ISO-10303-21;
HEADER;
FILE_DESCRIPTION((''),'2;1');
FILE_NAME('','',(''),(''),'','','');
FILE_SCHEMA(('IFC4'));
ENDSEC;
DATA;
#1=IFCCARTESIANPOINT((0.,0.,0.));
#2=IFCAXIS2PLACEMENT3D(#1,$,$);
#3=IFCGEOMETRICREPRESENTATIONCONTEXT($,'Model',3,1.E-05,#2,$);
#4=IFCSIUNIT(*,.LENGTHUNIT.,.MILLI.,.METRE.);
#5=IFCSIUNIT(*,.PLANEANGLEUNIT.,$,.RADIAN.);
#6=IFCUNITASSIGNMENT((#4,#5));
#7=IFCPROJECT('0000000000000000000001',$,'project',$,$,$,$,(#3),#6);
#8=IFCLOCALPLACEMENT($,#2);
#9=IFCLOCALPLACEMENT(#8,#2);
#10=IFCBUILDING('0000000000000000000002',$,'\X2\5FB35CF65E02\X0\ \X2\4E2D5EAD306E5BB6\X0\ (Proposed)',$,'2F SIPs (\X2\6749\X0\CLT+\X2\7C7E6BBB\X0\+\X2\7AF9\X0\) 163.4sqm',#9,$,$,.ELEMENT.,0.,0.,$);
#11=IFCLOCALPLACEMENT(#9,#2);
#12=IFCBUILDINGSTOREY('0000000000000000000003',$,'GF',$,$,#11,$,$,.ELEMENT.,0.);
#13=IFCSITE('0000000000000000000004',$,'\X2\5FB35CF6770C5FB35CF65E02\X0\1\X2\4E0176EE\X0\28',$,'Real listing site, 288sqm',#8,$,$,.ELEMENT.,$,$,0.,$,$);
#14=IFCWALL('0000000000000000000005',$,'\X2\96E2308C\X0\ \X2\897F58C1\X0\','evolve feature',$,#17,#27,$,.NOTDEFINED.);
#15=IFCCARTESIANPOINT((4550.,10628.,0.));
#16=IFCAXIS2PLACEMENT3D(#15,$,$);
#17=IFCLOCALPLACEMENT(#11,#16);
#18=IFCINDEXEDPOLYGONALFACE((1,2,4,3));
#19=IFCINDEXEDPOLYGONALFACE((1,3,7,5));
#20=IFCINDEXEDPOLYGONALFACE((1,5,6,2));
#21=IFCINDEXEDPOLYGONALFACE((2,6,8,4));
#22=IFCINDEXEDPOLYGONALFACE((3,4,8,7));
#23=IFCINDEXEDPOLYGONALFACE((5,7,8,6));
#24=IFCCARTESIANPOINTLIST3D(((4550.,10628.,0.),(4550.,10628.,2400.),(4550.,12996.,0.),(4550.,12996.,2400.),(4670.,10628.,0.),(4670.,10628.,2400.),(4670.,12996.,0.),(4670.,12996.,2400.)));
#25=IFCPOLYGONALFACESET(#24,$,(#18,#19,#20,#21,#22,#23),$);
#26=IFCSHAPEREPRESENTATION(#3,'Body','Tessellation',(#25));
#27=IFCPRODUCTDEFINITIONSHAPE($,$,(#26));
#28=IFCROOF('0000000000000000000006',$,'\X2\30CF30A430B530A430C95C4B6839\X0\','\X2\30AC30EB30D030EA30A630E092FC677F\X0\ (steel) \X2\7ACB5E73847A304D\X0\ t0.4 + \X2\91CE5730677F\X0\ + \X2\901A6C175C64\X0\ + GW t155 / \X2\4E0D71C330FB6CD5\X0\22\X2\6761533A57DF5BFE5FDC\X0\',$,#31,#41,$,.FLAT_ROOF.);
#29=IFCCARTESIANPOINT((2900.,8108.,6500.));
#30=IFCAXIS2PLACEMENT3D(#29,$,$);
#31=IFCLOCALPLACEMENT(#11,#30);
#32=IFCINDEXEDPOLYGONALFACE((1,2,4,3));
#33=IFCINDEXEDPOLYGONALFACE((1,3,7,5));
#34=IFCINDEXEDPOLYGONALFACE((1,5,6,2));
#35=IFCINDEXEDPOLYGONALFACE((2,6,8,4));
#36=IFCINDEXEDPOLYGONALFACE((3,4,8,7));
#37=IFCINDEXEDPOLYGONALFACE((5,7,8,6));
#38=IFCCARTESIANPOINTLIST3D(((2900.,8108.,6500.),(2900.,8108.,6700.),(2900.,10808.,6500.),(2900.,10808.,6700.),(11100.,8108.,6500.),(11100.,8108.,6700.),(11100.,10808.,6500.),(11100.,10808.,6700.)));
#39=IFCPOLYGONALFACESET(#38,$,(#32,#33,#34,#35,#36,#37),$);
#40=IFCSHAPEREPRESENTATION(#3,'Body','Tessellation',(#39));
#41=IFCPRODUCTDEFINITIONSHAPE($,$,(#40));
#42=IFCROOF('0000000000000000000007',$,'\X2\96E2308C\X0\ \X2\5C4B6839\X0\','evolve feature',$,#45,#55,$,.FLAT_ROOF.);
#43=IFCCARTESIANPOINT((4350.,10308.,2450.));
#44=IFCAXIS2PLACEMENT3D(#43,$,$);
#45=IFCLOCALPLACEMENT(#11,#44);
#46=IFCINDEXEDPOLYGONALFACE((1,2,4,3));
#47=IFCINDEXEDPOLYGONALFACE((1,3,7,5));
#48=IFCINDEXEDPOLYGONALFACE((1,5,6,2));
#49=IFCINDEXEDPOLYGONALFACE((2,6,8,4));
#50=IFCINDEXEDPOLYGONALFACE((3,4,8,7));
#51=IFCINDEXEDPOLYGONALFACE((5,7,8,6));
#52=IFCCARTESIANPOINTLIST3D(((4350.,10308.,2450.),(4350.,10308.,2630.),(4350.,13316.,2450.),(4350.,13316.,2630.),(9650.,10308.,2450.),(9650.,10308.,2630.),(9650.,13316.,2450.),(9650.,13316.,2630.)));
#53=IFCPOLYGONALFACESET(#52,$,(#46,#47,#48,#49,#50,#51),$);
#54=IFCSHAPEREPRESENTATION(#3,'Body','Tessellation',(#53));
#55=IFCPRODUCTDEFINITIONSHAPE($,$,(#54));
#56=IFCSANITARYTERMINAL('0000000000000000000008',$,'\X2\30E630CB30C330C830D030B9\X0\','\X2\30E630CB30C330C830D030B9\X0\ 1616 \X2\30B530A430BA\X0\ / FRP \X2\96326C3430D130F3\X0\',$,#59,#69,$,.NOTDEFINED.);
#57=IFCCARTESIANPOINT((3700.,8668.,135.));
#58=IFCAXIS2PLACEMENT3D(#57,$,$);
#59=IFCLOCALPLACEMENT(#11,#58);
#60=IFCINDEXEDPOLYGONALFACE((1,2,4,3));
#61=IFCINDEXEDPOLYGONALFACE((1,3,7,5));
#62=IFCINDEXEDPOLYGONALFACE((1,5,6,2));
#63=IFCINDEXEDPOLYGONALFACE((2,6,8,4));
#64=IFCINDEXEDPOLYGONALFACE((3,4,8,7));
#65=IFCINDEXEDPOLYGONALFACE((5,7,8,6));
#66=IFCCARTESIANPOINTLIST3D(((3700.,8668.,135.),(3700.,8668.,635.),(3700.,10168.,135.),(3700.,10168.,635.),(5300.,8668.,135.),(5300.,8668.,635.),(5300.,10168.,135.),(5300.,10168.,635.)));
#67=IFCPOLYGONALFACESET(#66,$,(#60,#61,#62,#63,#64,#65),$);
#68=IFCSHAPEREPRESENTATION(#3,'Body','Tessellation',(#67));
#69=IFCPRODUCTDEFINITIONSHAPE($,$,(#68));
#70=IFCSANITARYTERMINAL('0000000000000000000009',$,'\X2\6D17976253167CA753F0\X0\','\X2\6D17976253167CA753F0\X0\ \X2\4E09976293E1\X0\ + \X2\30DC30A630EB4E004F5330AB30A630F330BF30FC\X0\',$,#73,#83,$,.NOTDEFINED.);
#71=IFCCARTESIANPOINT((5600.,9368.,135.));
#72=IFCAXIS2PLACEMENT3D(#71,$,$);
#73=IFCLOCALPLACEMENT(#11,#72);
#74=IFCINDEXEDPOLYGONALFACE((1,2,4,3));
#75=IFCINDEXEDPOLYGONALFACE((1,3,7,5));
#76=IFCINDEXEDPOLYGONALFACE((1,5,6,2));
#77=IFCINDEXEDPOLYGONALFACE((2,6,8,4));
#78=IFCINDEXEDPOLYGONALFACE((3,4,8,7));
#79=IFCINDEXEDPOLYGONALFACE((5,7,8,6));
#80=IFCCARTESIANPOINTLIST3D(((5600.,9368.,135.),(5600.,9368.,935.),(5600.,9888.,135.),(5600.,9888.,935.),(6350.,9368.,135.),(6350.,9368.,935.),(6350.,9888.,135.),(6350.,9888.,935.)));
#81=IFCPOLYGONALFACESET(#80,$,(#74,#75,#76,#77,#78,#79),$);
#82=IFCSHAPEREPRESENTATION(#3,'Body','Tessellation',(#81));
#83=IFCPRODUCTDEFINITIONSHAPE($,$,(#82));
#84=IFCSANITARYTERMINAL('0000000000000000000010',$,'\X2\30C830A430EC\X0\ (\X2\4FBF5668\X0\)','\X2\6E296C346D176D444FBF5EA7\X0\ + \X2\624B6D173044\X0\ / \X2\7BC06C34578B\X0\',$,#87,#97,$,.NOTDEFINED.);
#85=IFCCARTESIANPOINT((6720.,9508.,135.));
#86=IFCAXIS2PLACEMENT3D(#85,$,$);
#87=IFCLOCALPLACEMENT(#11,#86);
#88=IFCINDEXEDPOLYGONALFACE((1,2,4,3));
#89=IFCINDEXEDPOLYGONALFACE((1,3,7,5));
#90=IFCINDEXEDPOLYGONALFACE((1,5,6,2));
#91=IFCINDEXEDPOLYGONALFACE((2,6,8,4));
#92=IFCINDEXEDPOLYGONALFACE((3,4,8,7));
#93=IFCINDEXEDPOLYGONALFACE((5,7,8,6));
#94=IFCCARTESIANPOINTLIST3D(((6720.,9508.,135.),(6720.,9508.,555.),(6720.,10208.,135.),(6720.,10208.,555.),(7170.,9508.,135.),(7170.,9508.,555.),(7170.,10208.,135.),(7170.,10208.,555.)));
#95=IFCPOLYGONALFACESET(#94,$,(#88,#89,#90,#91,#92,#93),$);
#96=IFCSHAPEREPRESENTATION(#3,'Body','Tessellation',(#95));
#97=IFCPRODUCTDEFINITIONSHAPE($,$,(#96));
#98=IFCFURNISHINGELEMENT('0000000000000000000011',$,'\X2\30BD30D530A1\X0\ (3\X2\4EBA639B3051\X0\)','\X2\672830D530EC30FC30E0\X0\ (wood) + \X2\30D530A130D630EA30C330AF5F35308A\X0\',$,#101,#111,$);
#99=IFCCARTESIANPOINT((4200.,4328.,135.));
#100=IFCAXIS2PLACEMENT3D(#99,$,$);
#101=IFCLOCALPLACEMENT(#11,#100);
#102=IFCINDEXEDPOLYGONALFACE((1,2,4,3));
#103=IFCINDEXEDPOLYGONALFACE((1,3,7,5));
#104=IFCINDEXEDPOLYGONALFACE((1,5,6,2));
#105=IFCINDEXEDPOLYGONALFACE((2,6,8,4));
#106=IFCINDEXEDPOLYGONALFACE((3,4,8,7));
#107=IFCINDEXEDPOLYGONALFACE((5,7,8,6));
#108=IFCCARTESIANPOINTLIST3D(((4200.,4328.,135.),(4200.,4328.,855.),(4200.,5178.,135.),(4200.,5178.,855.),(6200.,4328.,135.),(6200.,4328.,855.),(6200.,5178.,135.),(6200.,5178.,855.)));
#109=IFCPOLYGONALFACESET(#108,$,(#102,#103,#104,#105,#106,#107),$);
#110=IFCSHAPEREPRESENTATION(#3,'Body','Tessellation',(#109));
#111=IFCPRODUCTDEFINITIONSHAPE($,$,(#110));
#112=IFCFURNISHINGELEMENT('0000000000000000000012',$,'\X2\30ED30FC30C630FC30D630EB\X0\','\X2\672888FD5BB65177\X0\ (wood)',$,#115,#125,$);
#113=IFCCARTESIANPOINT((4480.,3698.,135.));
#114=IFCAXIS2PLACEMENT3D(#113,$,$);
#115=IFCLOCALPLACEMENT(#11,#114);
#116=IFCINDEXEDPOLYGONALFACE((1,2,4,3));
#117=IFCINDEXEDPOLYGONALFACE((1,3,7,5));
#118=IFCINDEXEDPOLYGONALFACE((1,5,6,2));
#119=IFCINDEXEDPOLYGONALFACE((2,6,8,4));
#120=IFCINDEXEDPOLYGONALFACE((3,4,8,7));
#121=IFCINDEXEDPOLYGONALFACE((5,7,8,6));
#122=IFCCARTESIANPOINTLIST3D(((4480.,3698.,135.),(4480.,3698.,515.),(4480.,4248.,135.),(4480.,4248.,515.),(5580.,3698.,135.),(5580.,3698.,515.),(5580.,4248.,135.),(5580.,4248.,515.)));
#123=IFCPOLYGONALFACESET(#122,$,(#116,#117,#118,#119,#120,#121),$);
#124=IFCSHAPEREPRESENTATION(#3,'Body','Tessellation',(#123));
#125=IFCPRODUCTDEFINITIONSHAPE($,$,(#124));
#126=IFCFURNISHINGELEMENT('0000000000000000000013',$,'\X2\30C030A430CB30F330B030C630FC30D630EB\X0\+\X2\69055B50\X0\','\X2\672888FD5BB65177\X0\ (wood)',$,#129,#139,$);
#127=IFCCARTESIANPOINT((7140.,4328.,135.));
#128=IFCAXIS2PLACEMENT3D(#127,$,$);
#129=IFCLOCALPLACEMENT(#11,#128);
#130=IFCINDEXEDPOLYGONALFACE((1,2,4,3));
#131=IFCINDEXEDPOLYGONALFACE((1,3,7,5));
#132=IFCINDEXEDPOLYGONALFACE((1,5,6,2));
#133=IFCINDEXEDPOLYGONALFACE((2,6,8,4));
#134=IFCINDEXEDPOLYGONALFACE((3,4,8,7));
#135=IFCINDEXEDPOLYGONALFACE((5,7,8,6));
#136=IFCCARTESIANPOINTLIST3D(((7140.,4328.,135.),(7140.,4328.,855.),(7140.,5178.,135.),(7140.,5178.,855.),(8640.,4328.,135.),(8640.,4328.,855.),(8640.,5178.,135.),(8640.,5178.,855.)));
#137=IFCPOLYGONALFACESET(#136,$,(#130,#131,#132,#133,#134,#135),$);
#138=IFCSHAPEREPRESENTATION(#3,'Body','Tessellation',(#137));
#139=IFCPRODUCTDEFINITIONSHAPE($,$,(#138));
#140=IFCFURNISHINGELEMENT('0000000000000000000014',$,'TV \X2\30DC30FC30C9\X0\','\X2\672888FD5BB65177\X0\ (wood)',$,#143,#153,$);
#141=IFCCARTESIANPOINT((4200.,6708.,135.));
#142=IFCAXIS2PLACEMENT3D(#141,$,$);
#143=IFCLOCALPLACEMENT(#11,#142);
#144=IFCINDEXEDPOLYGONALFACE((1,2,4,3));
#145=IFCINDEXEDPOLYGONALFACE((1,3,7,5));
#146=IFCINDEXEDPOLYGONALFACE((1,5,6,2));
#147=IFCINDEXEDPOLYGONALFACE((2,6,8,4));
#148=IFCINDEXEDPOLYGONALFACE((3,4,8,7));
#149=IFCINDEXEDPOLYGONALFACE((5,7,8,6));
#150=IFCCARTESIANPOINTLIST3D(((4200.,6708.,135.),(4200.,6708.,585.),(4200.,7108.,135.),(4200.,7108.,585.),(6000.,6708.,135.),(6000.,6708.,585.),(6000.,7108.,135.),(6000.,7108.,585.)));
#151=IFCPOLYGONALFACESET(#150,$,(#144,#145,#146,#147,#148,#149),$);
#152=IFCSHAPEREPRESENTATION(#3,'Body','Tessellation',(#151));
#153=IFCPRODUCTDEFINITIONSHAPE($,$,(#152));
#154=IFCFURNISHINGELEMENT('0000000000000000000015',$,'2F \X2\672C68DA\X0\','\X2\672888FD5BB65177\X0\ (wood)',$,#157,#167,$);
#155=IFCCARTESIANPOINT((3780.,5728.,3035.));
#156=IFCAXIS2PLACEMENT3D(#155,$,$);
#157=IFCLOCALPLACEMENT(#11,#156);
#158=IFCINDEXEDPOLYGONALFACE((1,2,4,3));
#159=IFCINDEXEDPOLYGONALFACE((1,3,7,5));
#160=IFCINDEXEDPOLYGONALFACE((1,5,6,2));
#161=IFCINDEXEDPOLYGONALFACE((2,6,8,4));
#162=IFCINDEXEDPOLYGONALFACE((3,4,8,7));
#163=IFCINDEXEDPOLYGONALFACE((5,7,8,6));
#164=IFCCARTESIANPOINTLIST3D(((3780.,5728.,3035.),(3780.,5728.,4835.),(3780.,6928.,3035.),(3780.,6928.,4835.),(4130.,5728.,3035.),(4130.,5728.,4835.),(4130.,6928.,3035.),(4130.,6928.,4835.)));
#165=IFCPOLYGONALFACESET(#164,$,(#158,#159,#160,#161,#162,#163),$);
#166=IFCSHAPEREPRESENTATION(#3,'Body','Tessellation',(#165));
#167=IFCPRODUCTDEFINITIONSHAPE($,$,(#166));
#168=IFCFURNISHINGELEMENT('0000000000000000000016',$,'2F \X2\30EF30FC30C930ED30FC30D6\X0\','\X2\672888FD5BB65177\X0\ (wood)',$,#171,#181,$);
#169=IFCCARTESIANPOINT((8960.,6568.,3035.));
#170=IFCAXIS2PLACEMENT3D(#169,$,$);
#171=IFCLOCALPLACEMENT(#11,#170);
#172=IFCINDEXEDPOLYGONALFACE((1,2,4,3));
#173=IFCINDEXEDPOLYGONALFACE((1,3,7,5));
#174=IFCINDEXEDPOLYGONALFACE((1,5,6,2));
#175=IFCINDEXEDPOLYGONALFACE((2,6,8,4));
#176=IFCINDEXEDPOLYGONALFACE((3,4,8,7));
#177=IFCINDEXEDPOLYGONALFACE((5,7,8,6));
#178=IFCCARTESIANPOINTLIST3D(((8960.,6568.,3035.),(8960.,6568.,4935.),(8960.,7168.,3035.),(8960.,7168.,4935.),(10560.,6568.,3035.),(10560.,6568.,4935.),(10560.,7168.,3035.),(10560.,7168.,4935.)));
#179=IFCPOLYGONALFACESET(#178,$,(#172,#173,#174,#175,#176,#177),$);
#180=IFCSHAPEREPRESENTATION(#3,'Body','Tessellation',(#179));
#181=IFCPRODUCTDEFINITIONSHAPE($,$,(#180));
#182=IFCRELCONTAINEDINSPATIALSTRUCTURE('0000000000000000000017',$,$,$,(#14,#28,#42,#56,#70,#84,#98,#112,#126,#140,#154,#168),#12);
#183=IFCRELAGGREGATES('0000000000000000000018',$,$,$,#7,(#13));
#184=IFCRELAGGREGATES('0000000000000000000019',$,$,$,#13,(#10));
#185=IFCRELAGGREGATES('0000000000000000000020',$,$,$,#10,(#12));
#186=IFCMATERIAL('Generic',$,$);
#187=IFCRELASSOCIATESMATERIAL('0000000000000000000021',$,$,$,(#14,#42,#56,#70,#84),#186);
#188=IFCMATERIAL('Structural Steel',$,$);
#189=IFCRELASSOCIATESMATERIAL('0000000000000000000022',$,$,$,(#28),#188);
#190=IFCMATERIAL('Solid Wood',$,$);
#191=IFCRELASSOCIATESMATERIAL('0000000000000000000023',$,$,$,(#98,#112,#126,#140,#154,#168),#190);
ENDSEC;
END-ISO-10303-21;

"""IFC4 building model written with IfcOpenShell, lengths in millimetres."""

from ifc_helpers import new_model, si_unit, frame, frame_2d, origin, place, context, project, spatial, rectangle, extrude, material, element, save


model = new_model("IFC4")

# Units and contexts
model_context = context("Model", 3, precision=1e-05, world=origin())
ifc_project = project(units=[si_unit("LENGTHUNIT", "METRE", prefix="MILLI"), si_unit("PLANEANGLEUNIT", "RADIAN")], contexts=[model_context])

# Site, building, storey
site_placement = place(None, origin())
site = spatial("IfcSite", under=ifc_project, at=site_placement, Name="徳島県徳島市1丁目28", ObjectType="Real listing site, 288sqm", CompositionType="ELEMENT", RefElevation=0.0)
building_placement = place(site_placement, origin())
building = spatial("IfcBuilding", under=site, at=building_placement, Name="徳島市 中庭の家 (Proposed)", ObjectType="2F SIPs (杉CLT+籾殻+竹) 163.4sqm", CompositionType="ELEMENT", ElevationOfRefHeight=0.0, ElevationOfTerrain=0.0)
storey_placement = place(building_placement, origin())
storey = spatial("IfcBuildingStorey", under=building, at=storey_placement, Name="GF", CompositionType="ELEMENT", Elevation=0.0)

# Shared definitions
ifc_material_1 = material(Name="Generic")

# Shared definitions
ifc_material_2 = material(Name="Solid Wood")

# Wall
wall_1_placement = place(storey_placement, frame((4550.0, 10628.0, 0.0)))
element("IfcWall", 1, at=wall_1_placement, inside=storey, material=ifc_material_1, Name="離れ 西壁", Description="evolve feature", PredefinedType="NOTDEFINED", context=model_context, shape_type="SweptSolid", body=[
    extrude(rectangle(XDim=120.0, YDim=2368.0, at=frame_2d((60.0, 1184.0))), frame((4550.0, 10628.0, 0.0)), (0.0, 0.0, 1.0), 2400.0),
])

# Roofs
ifc_material_3 = material(Name="Structural Steel")
roof_1_placement = place(storey_placement, frame((2900.0, 8108.0, 6500.0)))
element("IfcRoof", 2, at=roof_1_placement, inside=storey, material=ifc_material_3, Name="ハイサイド屋根", Description="ガルバリウム鋼板 (steel) 立平葺き t0.4 + 野地板 + 通気層 + GW t155 / 不燃・法22条区域対応", PredefinedType="FLAT_ROOF", context=model_context, shape_type="SweptSolid", body=[
    extrude(rectangle(XDim=8200.0, YDim=2700.0, at=frame_2d((4100.0, 1350.0))), frame((2900.0, 8108.0, 6500.0)), (0.0, 0.0, 1.0), 200.0),
])
roof_2_placement = place(storey_placement, frame((4350.0, 10308.0, 2450.0)))
element("IfcRoof", 3, at=roof_2_placement, inside=storey, material=ifc_material_1, Name="離れ 屋根", Description="evolve feature", PredefinedType="FLAT_ROOF", context=model_context, shape_type="SweptSolid", body=[
    extrude(rectangle(XDim=5300.0, YDim=3008.0, at=frame_2d((2650.0, 1504.0))), frame((4350.0, 10308.0, 2450.0)), (0.0, 0.0, 1.0), 180.0),
])

# Sanitary terminals
sanitary_terminal_1_placement = place(storey_placement, frame((3700.0, 8668.0, 135.0)))
element("IfcSanitaryTerminal", 4, at=sanitary_terminal_1_placement, inside=storey, material=ifc_material_1, Name="ユニットバス", Description="ユニットバス 1616 サイズ / FRP 防水パン", PredefinedType="NOTDEFINED", context=model_context, shape_type="SweptSolid", body=[
    extrude(rectangle(XDim=1600.0, YDim=1500.0, at=frame_2d((800.0, 750.0))), frame((3700.0, 8668.0, 135.0)), (0.0, 0.0, 1.0), 500.0),
])
sanitary_terminal_2_placement = place(storey_placement, frame((5600.0, 9368.0, 135.0)))
element("IfcSanitaryTerminal", 5, at=sanitary_terminal_2_placement, inside=storey, material=ifc_material_1, Name="洗面化粧台", Description="洗面化粧台 三面鏡 + ボウル一体カウンター", PredefinedType="NOTDEFINED", context=model_context, shape_type="SweptSolid", body=[
    extrude(rectangle(XDim=750.0, YDim=520.0, at=frame_2d((375.0, 260.0))), frame((5600.0, 9368.0, 135.0)), (0.0, 0.0, 1.0), 800.0),
])
sanitary_terminal_3_placement = place(storey_placement, frame((6720.0, 9508.0, 135.0)))
element("IfcSanitaryTerminal", 6, at=sanitary_terminal_3_placement, inside=storey, material=ifc_material_1, Name="トイレ (便器)", Description="温水洗浄便座 + 手洗い / 節水型", PredefinedType="NOTDEFINED", context=model_context, shape_type="SweptSolid", body=[
    extrude(rectangle(XDim=450.0, YDim=700.0, at=frame_2d((225.0, 350.0))), frame((6720.0, 9508.0, 135.0)), (0.0, 0.0, 1.0), 420.0),
])

# Furnishing elements
furnishing_1_placement = place(storey_placement, frame((4200.0, 4328.0, 135.0)))
element("IfcFurnishingElement", 7, at=furnishing_1_placement, inside=storey, material=ifc_material_2, Name="ソファ (3人掛け)", Description="木フレーム (wood) + ファブリック張り", context=model_context, shape_type="SweptSolid", body=[
    extrude(rectangle(XDim=2000.0, YDim=850.0, at=frame_2d((1000.0, 425.0))), frame((4200.0, 4328.0, 135.0)), (0.0, 0.0, 1.0), 720.0),
])
furnishing_2_placement = place(storey_placement, frame((4480.0, 3698.0, 135.0)))
element("IfcFurnishingElement", 8, at=furnishing_2_placement, inside=storey, material=ifc_material_2, Name="ローテーブル", Description="木製家具 (wood)", context=model_context, shape_type="SweptSolid", body=[
    extrude(rectangle(XDim=1100.0, YDim=550.0, at=frame_2d((550.0, 275.0))), frame((4480.0, 3698.0, 135.0)), (0.0, 0.0, 1.0), 380.0),
])
furnishing_3_placement = place(storey_placement, frame((7140.0, 4328.0, 135.0)))
element("IfcFurnishingElement", 9, at=furnishing_3_placement, inside=storey, material=ifc_material_2, Name="ダイニングテーブル+椅子", Description="木製家具 (wood)", context=model_context, shape_type="SweptSolid", body=[
    extrude(rectangle(XDim=1500.0, YDim=850.0, at=frame_2d((750.0, 425.0))), frame((7140.0, 4328.0, 135.0)), (0.0, 0.0, 1.0), 720.0),
])
furnishing_4_placement = place(storey_placement, frame((4200.0, 6708.0, 135.0)))
element("IfcFurnishingElement", 10, at=furnishing_4_placement, inside=storey, material=ifc_material_2, Name="TV ボード", Description="木製家具 (wood)", context=model_context, shape_type="SweptSolid", body=[
    extrude(rectangle(XDim=1800.0, YDim=400.0, at=frame_2d((900.0, 200.0))), frame((4200.0, 6708.0, 135.0)), (0.0, 0.0, 1.0), 450.0),
])
furnishing_5_placement = place(storey_placement, frame((3780.0, 5728.0, 3035.0)))
element("IfcFurnishingElement", 11, at=furnishing_5_placement, inside=storey, material=ifc_material_2, Name="2F 本棚", Description="木製家具 (wood)", context=model_context, shape_type="SweptSolid", body=[
    extrude(rectangle(XDim=350.0, YDim=1200.0, at=frame_2d((175.0, 600.0))), frame((3780.0, 5728.0, 3035.0)), (0.0, 0.0, 1.0), 1800.0),
])
furnishing_6_placement = place(storey_placement, frame((8960.0, 6568.0, 3035.0)))
element("IfcFurnishingElement", 12, at=furnishing_6_placement, inside=storey, material=ifc_material_2, Name="2F ワードローブ", Description="木製家具 (wood)", context=model_context, shape_type="SweptSolid", body=[
    extrude(rectangle(XDim=1600.0, YDim=600.0, at=frame_2d((800.0, 300.0))), frame((8960.0, 6568.0, 3035.0)), (0.0, 0.0, 1.0), 1900.0),
])

save(model, "model.ifc")
